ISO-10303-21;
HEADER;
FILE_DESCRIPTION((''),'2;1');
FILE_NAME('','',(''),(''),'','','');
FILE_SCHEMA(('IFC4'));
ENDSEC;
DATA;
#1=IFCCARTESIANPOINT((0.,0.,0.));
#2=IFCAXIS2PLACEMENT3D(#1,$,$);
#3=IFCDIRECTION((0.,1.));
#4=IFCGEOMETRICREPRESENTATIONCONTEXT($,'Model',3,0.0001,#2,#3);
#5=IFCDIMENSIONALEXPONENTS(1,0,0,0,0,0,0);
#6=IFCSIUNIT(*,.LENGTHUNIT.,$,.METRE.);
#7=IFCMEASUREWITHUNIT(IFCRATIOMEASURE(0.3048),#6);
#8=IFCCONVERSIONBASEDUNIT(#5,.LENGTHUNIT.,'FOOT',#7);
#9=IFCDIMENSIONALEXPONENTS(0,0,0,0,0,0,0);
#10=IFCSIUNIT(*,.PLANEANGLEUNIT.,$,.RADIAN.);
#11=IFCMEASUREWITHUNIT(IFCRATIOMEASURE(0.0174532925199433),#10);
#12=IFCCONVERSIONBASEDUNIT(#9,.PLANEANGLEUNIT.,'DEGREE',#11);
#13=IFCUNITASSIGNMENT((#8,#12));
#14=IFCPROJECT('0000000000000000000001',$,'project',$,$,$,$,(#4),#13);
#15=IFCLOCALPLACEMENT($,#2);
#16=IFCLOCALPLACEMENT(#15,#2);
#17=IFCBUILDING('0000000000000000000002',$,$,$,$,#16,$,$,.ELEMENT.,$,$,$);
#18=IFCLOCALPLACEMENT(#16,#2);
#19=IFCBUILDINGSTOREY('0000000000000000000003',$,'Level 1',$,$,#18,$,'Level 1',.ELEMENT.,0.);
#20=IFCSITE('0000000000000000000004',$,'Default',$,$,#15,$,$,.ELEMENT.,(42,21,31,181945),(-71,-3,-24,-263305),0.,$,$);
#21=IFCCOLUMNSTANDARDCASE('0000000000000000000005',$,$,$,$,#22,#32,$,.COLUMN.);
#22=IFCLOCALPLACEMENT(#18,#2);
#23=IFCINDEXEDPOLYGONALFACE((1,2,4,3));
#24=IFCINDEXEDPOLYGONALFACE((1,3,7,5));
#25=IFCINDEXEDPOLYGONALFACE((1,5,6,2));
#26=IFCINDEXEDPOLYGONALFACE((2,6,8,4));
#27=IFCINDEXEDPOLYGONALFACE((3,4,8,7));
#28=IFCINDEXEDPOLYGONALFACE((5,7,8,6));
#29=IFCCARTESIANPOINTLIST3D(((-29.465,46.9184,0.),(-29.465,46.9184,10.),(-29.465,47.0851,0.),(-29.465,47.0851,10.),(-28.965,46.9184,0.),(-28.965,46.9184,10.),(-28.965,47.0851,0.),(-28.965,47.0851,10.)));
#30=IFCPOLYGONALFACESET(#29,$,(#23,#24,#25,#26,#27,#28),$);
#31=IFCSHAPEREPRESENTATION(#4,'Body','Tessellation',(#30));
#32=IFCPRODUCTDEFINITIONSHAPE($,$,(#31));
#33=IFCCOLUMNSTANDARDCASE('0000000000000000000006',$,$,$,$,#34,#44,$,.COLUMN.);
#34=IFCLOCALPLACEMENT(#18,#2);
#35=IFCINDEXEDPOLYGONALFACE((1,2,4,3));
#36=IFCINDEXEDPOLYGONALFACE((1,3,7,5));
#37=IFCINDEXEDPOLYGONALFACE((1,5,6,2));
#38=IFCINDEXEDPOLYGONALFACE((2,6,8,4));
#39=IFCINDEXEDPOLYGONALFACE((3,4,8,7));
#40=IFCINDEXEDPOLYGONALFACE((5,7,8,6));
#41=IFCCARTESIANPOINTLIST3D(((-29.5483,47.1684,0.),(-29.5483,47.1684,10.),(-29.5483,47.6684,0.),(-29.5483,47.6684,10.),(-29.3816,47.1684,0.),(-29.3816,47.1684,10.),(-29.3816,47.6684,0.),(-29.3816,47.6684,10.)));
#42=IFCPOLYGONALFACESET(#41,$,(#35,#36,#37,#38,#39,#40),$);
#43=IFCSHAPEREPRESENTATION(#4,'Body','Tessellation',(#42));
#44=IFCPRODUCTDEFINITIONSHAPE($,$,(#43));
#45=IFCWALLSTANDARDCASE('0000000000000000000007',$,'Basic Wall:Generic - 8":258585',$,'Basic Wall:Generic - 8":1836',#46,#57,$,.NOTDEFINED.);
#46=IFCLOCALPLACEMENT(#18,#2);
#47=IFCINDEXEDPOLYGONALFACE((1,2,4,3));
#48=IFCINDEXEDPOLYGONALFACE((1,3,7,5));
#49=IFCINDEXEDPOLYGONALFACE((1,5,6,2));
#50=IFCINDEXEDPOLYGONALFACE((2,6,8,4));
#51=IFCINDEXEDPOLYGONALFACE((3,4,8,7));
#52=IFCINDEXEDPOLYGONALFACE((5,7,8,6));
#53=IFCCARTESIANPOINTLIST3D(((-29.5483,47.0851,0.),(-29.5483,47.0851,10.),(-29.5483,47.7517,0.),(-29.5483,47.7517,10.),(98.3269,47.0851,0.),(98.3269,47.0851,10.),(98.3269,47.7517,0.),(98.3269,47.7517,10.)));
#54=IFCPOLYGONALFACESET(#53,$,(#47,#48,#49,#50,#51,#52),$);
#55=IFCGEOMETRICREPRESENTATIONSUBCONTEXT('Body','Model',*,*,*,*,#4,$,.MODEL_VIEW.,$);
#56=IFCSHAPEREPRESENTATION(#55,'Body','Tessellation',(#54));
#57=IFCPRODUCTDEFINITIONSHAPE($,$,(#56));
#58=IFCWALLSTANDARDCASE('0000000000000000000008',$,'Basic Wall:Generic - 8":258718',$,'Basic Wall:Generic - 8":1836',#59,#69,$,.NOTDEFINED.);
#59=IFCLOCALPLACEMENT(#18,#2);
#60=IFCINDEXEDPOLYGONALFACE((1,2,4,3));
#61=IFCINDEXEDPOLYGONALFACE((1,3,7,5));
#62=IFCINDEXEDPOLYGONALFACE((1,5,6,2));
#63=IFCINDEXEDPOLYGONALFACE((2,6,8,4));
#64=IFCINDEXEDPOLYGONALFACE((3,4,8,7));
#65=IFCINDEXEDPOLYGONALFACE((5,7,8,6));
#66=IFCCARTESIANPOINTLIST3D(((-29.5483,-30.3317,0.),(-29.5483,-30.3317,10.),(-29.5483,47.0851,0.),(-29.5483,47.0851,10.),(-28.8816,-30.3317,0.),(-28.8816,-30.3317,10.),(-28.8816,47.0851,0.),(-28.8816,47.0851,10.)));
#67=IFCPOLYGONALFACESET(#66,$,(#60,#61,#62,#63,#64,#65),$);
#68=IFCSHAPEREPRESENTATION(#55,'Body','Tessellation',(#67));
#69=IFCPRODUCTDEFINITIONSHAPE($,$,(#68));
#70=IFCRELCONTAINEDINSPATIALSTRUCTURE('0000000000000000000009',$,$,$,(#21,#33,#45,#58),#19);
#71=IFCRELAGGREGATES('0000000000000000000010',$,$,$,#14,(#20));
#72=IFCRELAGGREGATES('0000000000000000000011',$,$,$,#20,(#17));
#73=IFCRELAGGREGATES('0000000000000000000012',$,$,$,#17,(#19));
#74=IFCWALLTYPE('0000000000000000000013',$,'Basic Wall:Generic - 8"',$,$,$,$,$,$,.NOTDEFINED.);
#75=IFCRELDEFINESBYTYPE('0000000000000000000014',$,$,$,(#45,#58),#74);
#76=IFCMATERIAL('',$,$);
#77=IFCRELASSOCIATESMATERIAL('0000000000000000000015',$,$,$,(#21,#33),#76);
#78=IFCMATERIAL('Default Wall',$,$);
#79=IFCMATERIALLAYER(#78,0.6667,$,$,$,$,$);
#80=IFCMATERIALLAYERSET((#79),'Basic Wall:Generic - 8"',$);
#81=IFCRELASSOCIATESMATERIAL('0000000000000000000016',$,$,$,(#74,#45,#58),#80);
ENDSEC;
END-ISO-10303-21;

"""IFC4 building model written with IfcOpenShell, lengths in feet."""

from ifc_helpers import new_model, entity, si_unit, converted_unit, direction, frame, frame_2d, origin, place, context, subcontext, project, spatial, rectangle, extrude, material, layer, layer_set, layer_usage, type_object, element, save


model = new_model("IFC4")

# Units and contexts
model_context = context("Model", 3, precision=0.0001, world=origin(), true_north=direction((0.0, 1.0)))
body_context = subcontext(model_context, "Body", "Model", "MODEL_VIEW")
ifc_project = project(units=[converted_unit("LENGTHUNIT", "FOOT", entity("IfcRatioMeasure", 0.3048), si_unit("LENGTHUNIT", "METRE"), dimensions=[1, 0, 0, 0, 0, 0, 0]), converted_unit("PLANEANGLEUNIT", "DEGREE", entity("IfcRatioMeasure", 0.0174532925199433), si_unit("PLANEANGLEUNIT", "RADIAN"), dimensions=[0, 0, 0, 0, 0, 0, 0])], contexts=[model_context])

# Site, building, storey
site_placement = place(None, origin())
site = spatial("IfcSite", under=ifc_project, at=site_placement, Name="Default", CompositionType="ELEMENT", RefLatitude=(42, 21, 31, 181945), RefLongitude=(-71, -3, -24, -263305), RefElevation=0.0)
building_placement = place(site_placement, origin())
building = spatial("IfcBuilding", under=site, at=building_placement, CompositionType="ELEMENT")
storey_placement = place(building_placement, origin())
storey = spatial("IfcBuildingStorey", under=building, at=storey_placement, Name="Level 1", LongName="Level 1", CompositionType="ELEMENT", Elevation=0.0)

# Columns
ifc_material_1 = material(Name="")
wall_1_placement = place(storey_placement, frame((-29.215, 47.0851, 0.0), z_axis=(0.0, 0.0, 1.0), x_axis=(0.0, -1.0, 0.0)))
for number, where, z_axis, x_axis in (
    (1, (0.0833, 0.0, 0.0), (0.0, 0.0, 1.0), (1.0, 0.0, 0.0)),
):
    element("IfcColumnStandardCase", number, at=place(wall_1_placement, frame(where, z_axis=z_axis, x_axis=x_axis)), inside=storey, material=ifc_material_1, PredefinedType="COLUMN", context=model_context, shape_type="SweptSolid", body=[
        extrude(rectangle(XDim=0.1667, YDim=0.5), origin(), (0.0, 0.0, 1.0), 10.0),
    ])
wall_2_placement = place(storey_placement, frame((-29.5483, 47.4184, 0.0)))
for number, where, z_axis, x_axis in (
    (2, (0.0833, 0.0, 0.0), (0.0, 0.0, 1.0), (1.0, 0.0, 0.0)),
):
    element("IfcColumnStandardCase", number, at=place(wall_2_placement, frame(where, z_axis=z_axis, x_axis=x_axis)), inside=storey, material=ifc_material_1, PredefinedType="COLUMN", context=model_context, shape_type="SweptSolid", body=[
        extrude(rectangle(XDim=0.1667, YDim=0.5), origin(), (0.0, 0.0, 1.0), 10.0),
    ])

# Walls
ifc_material_2 = material(Name="Default Wall")
ifc_layer = layer(ifc_material_2, 0.6667)
ifc_layer_set = layer_set([ifc_layer], Name="Basic Wall:Generic - 8\"")
ifc_layer_usage_1 = layer_usage(ifc_layer_set, "AXIS2", "NEGATIVE", 0.3333)
wall_type = type_object("IfcWallType", Name="Basic Wall:Generic - 8\"", PredefinedType="NOTDEFINED", material=ifc_layer_set)
element("IfcWallStandardCase", 3, at=wall_2_placement, inside=storey, type_object=wall_type, material=ifc_layer_usage_1, Name="Basic Wall:Generic - 8\":258585", ObjectType="Basic Wall:Generic - 8\":1836", PredefinedType="NOTDEFINED", context=body_context, shape_type="SweptSolid", body=[
    extrude(rectangle(XDim=127.8752, YDim=0.6667, at=frame_2d((63.9376, 0.0), x_axis=(-1.0, 0.0))), origin(), (0.0, 0.0, 1.0), 10.0),
])
ifc_layer_usage_2 = layer_usage(ifc_layer_set, "AXIS2", "NEGATIVE", 0.3333)
element("IfcWallStandardCase", 4, at=wall_1_placement, inside=storey, type_object=wall_type, material=ifc_layer_usage_2, Name="Basic Wall:Generic - 8\":258718", ObjectType="Basic Wall:Generic - 8\":1836", PredefinedType="NOTDEFINED", context=body_context, shape_type="SweptSolid", body=[
    extrude(rectangle(XDim=77.4167, YDim=0.6667, at=frame_2d((38.7084, 0.0), x_axis=(-1.0, 0.0))), origin(), (0.0, 0.0, 1.0), 10.0),
])

save(model, "model.ifc")
